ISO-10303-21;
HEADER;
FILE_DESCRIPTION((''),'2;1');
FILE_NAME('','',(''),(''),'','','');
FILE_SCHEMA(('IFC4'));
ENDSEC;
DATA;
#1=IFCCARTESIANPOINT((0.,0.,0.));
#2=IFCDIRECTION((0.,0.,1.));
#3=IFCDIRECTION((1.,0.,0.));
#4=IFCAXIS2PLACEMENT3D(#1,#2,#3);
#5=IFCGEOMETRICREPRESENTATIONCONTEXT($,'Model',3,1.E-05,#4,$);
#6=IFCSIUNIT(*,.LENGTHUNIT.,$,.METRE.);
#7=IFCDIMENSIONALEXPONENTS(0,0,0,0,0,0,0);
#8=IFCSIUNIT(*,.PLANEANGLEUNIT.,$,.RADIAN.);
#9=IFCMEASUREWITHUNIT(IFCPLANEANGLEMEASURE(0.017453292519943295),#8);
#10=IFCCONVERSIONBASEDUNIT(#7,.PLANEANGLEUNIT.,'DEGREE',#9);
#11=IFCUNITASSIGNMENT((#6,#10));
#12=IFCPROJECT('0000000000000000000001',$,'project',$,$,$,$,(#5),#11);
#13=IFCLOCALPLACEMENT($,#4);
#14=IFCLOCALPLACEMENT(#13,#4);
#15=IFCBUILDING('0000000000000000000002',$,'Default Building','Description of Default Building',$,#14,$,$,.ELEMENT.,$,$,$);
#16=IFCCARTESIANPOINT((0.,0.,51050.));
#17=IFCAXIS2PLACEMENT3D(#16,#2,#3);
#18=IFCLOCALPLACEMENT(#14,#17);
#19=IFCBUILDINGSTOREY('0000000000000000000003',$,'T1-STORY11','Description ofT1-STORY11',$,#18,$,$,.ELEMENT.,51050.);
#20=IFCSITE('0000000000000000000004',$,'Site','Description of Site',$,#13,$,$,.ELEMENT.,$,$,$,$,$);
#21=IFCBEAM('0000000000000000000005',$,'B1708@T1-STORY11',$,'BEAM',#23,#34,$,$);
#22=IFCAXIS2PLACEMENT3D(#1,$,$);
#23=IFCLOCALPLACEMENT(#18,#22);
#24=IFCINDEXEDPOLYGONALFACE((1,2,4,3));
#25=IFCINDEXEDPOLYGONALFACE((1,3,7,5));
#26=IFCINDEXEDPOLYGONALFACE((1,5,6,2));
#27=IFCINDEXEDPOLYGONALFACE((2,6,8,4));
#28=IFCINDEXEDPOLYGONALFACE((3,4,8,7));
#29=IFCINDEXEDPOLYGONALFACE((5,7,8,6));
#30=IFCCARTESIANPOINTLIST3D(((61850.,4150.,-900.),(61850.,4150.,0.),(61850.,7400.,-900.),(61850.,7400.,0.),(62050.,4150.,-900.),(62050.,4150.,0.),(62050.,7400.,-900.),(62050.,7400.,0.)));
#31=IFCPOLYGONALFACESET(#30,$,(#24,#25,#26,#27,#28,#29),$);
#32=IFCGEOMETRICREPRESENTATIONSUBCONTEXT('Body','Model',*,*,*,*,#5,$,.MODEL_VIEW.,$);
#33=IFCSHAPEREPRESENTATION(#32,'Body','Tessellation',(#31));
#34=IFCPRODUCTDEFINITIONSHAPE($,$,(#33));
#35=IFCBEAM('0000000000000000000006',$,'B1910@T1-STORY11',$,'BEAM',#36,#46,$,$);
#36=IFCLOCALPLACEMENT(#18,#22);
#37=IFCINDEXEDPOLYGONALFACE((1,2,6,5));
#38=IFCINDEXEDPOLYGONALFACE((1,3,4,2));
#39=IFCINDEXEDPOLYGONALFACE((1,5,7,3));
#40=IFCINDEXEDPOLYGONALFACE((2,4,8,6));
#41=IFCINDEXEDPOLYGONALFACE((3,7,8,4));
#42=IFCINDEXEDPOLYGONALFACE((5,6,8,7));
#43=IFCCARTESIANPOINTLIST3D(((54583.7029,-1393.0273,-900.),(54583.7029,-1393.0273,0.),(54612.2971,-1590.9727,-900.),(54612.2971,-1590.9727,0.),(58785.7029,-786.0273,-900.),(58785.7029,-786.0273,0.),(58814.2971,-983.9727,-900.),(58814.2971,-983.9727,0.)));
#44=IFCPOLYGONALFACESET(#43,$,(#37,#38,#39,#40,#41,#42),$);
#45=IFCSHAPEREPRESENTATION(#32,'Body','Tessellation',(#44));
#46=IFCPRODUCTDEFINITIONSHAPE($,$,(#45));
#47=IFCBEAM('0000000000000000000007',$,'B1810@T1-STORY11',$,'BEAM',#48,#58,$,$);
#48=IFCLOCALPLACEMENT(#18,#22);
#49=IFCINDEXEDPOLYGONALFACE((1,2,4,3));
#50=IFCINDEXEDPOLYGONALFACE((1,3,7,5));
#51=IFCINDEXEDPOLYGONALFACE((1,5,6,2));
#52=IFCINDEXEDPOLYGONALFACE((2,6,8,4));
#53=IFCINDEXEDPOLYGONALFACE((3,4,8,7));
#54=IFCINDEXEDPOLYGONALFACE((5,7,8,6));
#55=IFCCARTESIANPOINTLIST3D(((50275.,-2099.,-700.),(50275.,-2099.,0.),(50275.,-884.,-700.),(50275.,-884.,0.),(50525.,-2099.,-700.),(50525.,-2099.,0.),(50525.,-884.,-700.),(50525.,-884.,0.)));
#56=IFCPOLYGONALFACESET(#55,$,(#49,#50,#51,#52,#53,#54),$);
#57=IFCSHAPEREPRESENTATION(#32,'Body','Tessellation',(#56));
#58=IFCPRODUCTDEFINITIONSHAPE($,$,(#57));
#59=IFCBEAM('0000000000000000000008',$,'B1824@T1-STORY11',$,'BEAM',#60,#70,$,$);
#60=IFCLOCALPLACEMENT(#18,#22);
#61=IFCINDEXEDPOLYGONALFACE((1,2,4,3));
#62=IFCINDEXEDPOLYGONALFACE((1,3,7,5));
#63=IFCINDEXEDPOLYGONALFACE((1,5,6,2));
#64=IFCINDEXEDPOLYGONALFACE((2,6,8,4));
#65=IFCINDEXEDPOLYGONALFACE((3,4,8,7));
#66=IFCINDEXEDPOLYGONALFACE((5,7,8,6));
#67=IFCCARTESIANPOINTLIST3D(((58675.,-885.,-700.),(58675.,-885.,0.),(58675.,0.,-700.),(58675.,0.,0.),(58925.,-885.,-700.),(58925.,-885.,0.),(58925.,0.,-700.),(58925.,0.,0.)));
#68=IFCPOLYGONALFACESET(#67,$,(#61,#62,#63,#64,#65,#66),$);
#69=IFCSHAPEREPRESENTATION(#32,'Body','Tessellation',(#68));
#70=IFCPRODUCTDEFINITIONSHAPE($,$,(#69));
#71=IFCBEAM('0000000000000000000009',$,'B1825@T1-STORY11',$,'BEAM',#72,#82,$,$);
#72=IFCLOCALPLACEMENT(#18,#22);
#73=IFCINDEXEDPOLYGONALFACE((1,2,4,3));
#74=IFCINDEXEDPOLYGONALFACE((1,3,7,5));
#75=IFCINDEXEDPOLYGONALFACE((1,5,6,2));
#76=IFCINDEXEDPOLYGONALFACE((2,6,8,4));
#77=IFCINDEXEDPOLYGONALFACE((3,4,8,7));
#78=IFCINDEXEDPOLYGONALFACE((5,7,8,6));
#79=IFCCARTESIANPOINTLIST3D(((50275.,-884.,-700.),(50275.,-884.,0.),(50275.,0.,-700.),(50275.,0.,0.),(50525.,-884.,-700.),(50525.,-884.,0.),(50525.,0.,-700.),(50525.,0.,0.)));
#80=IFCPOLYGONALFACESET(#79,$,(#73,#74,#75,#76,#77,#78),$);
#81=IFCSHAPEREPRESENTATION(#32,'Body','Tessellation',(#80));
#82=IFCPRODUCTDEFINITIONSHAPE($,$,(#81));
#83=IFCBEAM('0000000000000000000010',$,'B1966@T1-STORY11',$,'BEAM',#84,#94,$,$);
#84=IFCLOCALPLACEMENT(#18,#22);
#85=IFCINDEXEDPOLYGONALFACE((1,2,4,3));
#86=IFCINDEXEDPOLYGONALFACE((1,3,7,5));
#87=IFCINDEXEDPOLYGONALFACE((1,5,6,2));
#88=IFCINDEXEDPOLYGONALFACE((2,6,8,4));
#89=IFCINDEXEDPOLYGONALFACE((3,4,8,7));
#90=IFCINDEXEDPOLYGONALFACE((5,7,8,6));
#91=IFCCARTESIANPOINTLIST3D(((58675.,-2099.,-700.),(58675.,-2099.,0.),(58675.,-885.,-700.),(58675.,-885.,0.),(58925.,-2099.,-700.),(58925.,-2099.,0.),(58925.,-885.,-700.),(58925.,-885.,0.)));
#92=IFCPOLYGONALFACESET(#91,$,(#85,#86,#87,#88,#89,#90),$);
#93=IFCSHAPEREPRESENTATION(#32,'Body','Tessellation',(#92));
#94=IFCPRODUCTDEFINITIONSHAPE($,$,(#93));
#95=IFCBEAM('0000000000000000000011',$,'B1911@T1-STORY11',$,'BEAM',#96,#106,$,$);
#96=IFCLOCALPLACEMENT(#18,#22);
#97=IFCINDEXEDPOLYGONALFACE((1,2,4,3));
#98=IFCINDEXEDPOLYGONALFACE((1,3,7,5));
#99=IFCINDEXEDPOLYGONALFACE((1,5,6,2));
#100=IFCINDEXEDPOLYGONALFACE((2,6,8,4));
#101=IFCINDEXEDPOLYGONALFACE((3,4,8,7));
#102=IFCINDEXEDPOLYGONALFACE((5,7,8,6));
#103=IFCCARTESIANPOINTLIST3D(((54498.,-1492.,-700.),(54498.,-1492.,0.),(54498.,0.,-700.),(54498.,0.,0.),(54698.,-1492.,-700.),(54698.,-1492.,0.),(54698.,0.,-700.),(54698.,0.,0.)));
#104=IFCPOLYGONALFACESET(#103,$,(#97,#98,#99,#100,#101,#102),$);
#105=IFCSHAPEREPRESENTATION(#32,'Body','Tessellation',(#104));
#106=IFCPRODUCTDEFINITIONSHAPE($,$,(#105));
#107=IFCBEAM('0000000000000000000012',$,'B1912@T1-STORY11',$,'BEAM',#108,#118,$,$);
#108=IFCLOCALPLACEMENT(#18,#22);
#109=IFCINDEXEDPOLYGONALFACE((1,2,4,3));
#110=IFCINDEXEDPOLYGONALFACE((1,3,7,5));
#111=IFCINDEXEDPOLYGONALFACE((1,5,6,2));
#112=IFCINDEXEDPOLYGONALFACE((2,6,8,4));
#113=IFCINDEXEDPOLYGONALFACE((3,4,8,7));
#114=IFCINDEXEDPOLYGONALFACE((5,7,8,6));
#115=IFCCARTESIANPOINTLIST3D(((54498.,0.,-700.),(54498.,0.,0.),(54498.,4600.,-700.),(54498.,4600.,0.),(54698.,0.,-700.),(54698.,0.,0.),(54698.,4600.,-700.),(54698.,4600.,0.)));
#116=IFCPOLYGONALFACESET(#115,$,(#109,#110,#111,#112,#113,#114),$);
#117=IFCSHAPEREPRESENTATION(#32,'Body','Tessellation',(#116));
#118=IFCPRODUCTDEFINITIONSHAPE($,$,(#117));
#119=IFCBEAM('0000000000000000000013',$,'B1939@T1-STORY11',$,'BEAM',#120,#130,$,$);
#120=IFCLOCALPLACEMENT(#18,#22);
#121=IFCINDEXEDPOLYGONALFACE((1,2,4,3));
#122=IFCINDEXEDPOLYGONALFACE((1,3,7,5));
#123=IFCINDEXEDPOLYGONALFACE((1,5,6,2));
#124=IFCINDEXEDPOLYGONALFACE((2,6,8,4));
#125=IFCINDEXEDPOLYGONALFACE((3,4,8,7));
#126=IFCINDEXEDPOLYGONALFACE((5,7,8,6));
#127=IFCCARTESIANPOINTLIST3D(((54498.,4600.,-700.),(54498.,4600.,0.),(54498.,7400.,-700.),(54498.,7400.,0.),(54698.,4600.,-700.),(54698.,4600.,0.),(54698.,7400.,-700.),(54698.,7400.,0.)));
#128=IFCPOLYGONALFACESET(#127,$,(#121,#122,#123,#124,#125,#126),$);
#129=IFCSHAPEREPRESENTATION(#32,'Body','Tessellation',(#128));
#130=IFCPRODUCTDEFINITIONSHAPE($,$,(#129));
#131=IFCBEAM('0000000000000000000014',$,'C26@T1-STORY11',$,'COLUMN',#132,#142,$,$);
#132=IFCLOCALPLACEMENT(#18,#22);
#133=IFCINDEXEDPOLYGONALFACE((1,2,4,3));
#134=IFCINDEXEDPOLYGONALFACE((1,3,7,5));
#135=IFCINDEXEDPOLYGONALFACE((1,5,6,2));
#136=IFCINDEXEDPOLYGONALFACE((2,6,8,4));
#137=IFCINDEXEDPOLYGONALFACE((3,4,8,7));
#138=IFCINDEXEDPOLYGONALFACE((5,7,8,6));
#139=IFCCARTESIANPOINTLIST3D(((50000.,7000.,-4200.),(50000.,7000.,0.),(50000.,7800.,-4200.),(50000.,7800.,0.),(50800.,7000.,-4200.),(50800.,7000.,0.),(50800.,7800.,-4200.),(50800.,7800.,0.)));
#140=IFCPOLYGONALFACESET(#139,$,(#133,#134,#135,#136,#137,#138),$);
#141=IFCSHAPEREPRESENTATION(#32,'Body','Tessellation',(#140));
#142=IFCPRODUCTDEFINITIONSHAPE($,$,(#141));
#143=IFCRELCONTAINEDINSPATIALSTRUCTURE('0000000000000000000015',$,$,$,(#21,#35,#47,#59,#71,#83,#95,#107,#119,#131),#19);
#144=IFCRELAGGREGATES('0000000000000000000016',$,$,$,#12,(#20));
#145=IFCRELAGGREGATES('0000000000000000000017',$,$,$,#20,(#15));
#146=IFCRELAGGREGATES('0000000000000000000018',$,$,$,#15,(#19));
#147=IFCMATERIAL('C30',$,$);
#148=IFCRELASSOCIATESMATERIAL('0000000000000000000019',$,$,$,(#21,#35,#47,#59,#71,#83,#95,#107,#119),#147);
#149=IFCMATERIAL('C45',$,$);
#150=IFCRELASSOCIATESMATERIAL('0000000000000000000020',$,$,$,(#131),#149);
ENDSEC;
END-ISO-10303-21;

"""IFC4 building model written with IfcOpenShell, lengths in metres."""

from ifc_helpers import new_model, entity, si_unit, converted_unit, frame, origin_with_axes, place, context, subcontext, project, spatial, rectangle, extrude, material, element, save


model = new_model("IFC4")

# Units and contexts
model_context = context("Model", 3, precision=1e-05, world=origin_with_axes())
body_context = subcontext(model_context, "Body", "Model", "MODEL_VIEW")
ifc_project = project(units=[si_unit("LENGTHUNIT", "METRE"), converted_unit("PLANEANGLEUNIT", "DEGREE", entity("IfcPlaneAngleMeasure", 0.017453292519943295), si_unit("PLANEANGLEUNIT", "RADIAN"), dimensions=[0, 0, 0, 0, 0, 0, 0])], contexts=[model_context])

# Site, building, storey
site_placement = place(None, origin_with_axes())
site = spatial("IfcSite", under=ifc_project, at=site_placement, Name="Site", Description="Description of Site", CompositionType="ELEMENT")
building_placement = place(site_placement, origin_with_axes())
building = spatial("IfcBuilding", under=site, at=building_placement, Name="Default Building", Description="Description of Default Building", CompositionType="ELEMENT")
storey_placement = place(building_placement, frame((0.0, 0.0, 51050.0), z_axis=(0.0, 0.0, 1.0), x_axis=(1.0, 0.0, 0.0)))
storey = spatial("IfcBuildingStorey", under=building, at=storey_placement, Name="T1-STORY11", Description="Description ofT1-STORY11", CompositionType="ELEMENT", Elevation=51050.0)

# Beams
ifc_material_1 = material(Name="C30")
beam_1_placement = place(storey_placement, frame((61950.0, 4150.0, -450.0), z_axis=(0.0, 1.0, 0.0), x_axis=(-1.0, 0.0, 0.0)))
element("IfcBeam", 1, at=beam_1_placement, inside=storey, material=ifc_material_1, Name="B1708@T1-STORY11", ObjectType="BEAM", context=body_context, shape_type="SweptSolid", body=[
    extrude(rectangle(XDim=200.0, YDim=900.0), origin_with_axes(), (0.0, 0.0, 1.0), 3250.0),
])
beam_2_placement = place(storey_placement, frame((54598.0, -1492.0, -450.0), z_axis=(0.989727, 0.142971, 0.0), x_axis=(-0.142971, 0.989727, 0.0)))
element("IfcBeam", 2, at=beam_2_placement, inside=storey, material=ifc_material_1, Name="B1910@T1-STORY11", ObjectType="BEAM", context=body_context, shape_type="SweptSolid", body=[
    extrude(rectangle(XDim=200.0, YDim=900.0), origin_with_axes(), (0.0, 0.0, 1.0), 4245.6157),
])
beam_3_placement = place(storey_placement, frame((50400.0, -2099.0, -350.0), z_axis=(0.0, 1.0, 0.0), x_axis=(-1.0, 0.0, 0.0)))
element("IfcBeam", 3, at=beam_3_placement, inside=storey, material=ifc_material_1, Name="B1810@T1-STORY11", ObjectType="BEAM", context=body_context, shape_type="SweptSolid", body=[
    extrude(rectangle(XDim=250.0, YDim=700.0), origin_with_axes(), (0.0, 0.0, 1.0), 1215.0),
])
beam_4_placement = place(storey_placement, frame((58800.0, -885.0, -350.0), z_axis=(0.0, 1.0, 0.0), x_axis=(-1.0, 0.0, 0.0)))
element("IfcBeam", 4, at=beam_4_placement, inside=storey, material=ifc_material_1, Name="B1824@T1-STORY11", ObjectType="BEAM", context=body_context, shape_type="SweptSolid", body=[
    extrude(rectangle(XDim=250.0, YDim=700.0), origin_with_axes(), (0.0, 0.0, 1.0), 885.0),
])
beam_5_placement = place(storey_placement, frame((50400.0, -884.0, -350.0), z_axis=(0.0, 1.0, 0.0), x_axis=(-1.0, 0.0, 0.0)))
element("IfcBeam", 5, at=beam_5_placement, inside=storey, material=ifc_material_1, Name="B1825@T1-STORY11", ObjectType="BEAM", context=body_context, shape_type="SweptSolid", body=[
    extrude(rectangle(XDim=250.0, YDim=700.0), origin_with_axes(), (0.0, 0.0, 1.0), 884.0),
])
beam_6_placement = place(storey_placement, frame((58800.0, -2099.0, -350.0), z_axis=(0.0, 1.0, 0.0), x_axis=(-1.0, 0.0, 0.0)))
element("IfcBeam", 6, at=beam_6_placement, inside=storey, material=ifc_material_1, Name="B1966@T1-STORY11", ObjectType="BEAM", context=body_context, shape_type="SweptSolid", body=[
    extrude(rectangle(XDim=250.0, YDim=700.0), origin_with_axes(), (0.0, 0.0, 1.0), 1214.0),
])
beam_7_placement = place(storey_placement, frame((54598.0, -1492.0, -350.0), z_axis=(0.0, 1.0, 0.0), x_axis=(-1.0, 0.0, 0.0)))
element("IfcBeam", 7, at=beam_7_placement, inside=storey, material=ifc_material_1, Name="B1911@T1-STORY11", ObjectType="BEAM", context=body_context, shape_type="SweptSolid", body=[
    extrude(rectangle(XDim=200.0, YDim=700.0), origin_with_axes(), (0.0, 0.0, 1.0), 1492.0),
])
beam_8_placement = place(storey_placement, frame((54598.0, 0.0, -350.0), z_axis=(0.0, 1.0, 0.0), x_axis=(-1.0, 0.0, 0.0)))
element("IfcBeam", 8, at=beam_8_placement, inside=storey, material=ifc_material_1, Name="B1912@T1-STORY11", ObjectType="BEAM", context=body_context, shape_type="SweptSolid", body=[
    extrude(rectangle(XDim=200.0, YDim=700.0), origin_with_axes(), (0.0, 0.0, 1.0), 4600.0),
])
beam_9_placement = place(storey_placement, frame((54598.0, 4600.0, -350.0), z_axis=(0.0, 1.0, 0.0), x_axis=(-1.0, 0.0, 0.0)))
element("IfcBeam", 9, at=beam_9_placement, inside=storey, material=ifc_material_1, Name="B1939@T1-STORY11", ObjectType="BEAM", context=body_context, shape_type="SweptSolid", body=[
    extrude(rectangle(XDim=200.0, YDim=700.0), origin_with_axes(), (0.0, 0.0, 1.0), 2800.0),
])
ifc_material_2 = material(Name="C45")
beam_10_placement = place(storey_placement, frame((50400.0, 7400.0, -4200.0), z_axis=(0.0, 0.0, 1.0), x_axis=(-1.0, 0.0, 0.0)))
element("IfcBeam", 10, at=beam_10_placement, inside=storey, material=ifc_material_2, Name="C26@T1-STORY11", ObjectType="COLUMN", context=body_context, shape_type="SweptSolid", body=[
    extrude(rectangle(XDim=800.0, YDim=800.0), origin_with_axes(), (0.0, 0.0, 1.0), 4200.0),
])

save(model, "model.ifc")
